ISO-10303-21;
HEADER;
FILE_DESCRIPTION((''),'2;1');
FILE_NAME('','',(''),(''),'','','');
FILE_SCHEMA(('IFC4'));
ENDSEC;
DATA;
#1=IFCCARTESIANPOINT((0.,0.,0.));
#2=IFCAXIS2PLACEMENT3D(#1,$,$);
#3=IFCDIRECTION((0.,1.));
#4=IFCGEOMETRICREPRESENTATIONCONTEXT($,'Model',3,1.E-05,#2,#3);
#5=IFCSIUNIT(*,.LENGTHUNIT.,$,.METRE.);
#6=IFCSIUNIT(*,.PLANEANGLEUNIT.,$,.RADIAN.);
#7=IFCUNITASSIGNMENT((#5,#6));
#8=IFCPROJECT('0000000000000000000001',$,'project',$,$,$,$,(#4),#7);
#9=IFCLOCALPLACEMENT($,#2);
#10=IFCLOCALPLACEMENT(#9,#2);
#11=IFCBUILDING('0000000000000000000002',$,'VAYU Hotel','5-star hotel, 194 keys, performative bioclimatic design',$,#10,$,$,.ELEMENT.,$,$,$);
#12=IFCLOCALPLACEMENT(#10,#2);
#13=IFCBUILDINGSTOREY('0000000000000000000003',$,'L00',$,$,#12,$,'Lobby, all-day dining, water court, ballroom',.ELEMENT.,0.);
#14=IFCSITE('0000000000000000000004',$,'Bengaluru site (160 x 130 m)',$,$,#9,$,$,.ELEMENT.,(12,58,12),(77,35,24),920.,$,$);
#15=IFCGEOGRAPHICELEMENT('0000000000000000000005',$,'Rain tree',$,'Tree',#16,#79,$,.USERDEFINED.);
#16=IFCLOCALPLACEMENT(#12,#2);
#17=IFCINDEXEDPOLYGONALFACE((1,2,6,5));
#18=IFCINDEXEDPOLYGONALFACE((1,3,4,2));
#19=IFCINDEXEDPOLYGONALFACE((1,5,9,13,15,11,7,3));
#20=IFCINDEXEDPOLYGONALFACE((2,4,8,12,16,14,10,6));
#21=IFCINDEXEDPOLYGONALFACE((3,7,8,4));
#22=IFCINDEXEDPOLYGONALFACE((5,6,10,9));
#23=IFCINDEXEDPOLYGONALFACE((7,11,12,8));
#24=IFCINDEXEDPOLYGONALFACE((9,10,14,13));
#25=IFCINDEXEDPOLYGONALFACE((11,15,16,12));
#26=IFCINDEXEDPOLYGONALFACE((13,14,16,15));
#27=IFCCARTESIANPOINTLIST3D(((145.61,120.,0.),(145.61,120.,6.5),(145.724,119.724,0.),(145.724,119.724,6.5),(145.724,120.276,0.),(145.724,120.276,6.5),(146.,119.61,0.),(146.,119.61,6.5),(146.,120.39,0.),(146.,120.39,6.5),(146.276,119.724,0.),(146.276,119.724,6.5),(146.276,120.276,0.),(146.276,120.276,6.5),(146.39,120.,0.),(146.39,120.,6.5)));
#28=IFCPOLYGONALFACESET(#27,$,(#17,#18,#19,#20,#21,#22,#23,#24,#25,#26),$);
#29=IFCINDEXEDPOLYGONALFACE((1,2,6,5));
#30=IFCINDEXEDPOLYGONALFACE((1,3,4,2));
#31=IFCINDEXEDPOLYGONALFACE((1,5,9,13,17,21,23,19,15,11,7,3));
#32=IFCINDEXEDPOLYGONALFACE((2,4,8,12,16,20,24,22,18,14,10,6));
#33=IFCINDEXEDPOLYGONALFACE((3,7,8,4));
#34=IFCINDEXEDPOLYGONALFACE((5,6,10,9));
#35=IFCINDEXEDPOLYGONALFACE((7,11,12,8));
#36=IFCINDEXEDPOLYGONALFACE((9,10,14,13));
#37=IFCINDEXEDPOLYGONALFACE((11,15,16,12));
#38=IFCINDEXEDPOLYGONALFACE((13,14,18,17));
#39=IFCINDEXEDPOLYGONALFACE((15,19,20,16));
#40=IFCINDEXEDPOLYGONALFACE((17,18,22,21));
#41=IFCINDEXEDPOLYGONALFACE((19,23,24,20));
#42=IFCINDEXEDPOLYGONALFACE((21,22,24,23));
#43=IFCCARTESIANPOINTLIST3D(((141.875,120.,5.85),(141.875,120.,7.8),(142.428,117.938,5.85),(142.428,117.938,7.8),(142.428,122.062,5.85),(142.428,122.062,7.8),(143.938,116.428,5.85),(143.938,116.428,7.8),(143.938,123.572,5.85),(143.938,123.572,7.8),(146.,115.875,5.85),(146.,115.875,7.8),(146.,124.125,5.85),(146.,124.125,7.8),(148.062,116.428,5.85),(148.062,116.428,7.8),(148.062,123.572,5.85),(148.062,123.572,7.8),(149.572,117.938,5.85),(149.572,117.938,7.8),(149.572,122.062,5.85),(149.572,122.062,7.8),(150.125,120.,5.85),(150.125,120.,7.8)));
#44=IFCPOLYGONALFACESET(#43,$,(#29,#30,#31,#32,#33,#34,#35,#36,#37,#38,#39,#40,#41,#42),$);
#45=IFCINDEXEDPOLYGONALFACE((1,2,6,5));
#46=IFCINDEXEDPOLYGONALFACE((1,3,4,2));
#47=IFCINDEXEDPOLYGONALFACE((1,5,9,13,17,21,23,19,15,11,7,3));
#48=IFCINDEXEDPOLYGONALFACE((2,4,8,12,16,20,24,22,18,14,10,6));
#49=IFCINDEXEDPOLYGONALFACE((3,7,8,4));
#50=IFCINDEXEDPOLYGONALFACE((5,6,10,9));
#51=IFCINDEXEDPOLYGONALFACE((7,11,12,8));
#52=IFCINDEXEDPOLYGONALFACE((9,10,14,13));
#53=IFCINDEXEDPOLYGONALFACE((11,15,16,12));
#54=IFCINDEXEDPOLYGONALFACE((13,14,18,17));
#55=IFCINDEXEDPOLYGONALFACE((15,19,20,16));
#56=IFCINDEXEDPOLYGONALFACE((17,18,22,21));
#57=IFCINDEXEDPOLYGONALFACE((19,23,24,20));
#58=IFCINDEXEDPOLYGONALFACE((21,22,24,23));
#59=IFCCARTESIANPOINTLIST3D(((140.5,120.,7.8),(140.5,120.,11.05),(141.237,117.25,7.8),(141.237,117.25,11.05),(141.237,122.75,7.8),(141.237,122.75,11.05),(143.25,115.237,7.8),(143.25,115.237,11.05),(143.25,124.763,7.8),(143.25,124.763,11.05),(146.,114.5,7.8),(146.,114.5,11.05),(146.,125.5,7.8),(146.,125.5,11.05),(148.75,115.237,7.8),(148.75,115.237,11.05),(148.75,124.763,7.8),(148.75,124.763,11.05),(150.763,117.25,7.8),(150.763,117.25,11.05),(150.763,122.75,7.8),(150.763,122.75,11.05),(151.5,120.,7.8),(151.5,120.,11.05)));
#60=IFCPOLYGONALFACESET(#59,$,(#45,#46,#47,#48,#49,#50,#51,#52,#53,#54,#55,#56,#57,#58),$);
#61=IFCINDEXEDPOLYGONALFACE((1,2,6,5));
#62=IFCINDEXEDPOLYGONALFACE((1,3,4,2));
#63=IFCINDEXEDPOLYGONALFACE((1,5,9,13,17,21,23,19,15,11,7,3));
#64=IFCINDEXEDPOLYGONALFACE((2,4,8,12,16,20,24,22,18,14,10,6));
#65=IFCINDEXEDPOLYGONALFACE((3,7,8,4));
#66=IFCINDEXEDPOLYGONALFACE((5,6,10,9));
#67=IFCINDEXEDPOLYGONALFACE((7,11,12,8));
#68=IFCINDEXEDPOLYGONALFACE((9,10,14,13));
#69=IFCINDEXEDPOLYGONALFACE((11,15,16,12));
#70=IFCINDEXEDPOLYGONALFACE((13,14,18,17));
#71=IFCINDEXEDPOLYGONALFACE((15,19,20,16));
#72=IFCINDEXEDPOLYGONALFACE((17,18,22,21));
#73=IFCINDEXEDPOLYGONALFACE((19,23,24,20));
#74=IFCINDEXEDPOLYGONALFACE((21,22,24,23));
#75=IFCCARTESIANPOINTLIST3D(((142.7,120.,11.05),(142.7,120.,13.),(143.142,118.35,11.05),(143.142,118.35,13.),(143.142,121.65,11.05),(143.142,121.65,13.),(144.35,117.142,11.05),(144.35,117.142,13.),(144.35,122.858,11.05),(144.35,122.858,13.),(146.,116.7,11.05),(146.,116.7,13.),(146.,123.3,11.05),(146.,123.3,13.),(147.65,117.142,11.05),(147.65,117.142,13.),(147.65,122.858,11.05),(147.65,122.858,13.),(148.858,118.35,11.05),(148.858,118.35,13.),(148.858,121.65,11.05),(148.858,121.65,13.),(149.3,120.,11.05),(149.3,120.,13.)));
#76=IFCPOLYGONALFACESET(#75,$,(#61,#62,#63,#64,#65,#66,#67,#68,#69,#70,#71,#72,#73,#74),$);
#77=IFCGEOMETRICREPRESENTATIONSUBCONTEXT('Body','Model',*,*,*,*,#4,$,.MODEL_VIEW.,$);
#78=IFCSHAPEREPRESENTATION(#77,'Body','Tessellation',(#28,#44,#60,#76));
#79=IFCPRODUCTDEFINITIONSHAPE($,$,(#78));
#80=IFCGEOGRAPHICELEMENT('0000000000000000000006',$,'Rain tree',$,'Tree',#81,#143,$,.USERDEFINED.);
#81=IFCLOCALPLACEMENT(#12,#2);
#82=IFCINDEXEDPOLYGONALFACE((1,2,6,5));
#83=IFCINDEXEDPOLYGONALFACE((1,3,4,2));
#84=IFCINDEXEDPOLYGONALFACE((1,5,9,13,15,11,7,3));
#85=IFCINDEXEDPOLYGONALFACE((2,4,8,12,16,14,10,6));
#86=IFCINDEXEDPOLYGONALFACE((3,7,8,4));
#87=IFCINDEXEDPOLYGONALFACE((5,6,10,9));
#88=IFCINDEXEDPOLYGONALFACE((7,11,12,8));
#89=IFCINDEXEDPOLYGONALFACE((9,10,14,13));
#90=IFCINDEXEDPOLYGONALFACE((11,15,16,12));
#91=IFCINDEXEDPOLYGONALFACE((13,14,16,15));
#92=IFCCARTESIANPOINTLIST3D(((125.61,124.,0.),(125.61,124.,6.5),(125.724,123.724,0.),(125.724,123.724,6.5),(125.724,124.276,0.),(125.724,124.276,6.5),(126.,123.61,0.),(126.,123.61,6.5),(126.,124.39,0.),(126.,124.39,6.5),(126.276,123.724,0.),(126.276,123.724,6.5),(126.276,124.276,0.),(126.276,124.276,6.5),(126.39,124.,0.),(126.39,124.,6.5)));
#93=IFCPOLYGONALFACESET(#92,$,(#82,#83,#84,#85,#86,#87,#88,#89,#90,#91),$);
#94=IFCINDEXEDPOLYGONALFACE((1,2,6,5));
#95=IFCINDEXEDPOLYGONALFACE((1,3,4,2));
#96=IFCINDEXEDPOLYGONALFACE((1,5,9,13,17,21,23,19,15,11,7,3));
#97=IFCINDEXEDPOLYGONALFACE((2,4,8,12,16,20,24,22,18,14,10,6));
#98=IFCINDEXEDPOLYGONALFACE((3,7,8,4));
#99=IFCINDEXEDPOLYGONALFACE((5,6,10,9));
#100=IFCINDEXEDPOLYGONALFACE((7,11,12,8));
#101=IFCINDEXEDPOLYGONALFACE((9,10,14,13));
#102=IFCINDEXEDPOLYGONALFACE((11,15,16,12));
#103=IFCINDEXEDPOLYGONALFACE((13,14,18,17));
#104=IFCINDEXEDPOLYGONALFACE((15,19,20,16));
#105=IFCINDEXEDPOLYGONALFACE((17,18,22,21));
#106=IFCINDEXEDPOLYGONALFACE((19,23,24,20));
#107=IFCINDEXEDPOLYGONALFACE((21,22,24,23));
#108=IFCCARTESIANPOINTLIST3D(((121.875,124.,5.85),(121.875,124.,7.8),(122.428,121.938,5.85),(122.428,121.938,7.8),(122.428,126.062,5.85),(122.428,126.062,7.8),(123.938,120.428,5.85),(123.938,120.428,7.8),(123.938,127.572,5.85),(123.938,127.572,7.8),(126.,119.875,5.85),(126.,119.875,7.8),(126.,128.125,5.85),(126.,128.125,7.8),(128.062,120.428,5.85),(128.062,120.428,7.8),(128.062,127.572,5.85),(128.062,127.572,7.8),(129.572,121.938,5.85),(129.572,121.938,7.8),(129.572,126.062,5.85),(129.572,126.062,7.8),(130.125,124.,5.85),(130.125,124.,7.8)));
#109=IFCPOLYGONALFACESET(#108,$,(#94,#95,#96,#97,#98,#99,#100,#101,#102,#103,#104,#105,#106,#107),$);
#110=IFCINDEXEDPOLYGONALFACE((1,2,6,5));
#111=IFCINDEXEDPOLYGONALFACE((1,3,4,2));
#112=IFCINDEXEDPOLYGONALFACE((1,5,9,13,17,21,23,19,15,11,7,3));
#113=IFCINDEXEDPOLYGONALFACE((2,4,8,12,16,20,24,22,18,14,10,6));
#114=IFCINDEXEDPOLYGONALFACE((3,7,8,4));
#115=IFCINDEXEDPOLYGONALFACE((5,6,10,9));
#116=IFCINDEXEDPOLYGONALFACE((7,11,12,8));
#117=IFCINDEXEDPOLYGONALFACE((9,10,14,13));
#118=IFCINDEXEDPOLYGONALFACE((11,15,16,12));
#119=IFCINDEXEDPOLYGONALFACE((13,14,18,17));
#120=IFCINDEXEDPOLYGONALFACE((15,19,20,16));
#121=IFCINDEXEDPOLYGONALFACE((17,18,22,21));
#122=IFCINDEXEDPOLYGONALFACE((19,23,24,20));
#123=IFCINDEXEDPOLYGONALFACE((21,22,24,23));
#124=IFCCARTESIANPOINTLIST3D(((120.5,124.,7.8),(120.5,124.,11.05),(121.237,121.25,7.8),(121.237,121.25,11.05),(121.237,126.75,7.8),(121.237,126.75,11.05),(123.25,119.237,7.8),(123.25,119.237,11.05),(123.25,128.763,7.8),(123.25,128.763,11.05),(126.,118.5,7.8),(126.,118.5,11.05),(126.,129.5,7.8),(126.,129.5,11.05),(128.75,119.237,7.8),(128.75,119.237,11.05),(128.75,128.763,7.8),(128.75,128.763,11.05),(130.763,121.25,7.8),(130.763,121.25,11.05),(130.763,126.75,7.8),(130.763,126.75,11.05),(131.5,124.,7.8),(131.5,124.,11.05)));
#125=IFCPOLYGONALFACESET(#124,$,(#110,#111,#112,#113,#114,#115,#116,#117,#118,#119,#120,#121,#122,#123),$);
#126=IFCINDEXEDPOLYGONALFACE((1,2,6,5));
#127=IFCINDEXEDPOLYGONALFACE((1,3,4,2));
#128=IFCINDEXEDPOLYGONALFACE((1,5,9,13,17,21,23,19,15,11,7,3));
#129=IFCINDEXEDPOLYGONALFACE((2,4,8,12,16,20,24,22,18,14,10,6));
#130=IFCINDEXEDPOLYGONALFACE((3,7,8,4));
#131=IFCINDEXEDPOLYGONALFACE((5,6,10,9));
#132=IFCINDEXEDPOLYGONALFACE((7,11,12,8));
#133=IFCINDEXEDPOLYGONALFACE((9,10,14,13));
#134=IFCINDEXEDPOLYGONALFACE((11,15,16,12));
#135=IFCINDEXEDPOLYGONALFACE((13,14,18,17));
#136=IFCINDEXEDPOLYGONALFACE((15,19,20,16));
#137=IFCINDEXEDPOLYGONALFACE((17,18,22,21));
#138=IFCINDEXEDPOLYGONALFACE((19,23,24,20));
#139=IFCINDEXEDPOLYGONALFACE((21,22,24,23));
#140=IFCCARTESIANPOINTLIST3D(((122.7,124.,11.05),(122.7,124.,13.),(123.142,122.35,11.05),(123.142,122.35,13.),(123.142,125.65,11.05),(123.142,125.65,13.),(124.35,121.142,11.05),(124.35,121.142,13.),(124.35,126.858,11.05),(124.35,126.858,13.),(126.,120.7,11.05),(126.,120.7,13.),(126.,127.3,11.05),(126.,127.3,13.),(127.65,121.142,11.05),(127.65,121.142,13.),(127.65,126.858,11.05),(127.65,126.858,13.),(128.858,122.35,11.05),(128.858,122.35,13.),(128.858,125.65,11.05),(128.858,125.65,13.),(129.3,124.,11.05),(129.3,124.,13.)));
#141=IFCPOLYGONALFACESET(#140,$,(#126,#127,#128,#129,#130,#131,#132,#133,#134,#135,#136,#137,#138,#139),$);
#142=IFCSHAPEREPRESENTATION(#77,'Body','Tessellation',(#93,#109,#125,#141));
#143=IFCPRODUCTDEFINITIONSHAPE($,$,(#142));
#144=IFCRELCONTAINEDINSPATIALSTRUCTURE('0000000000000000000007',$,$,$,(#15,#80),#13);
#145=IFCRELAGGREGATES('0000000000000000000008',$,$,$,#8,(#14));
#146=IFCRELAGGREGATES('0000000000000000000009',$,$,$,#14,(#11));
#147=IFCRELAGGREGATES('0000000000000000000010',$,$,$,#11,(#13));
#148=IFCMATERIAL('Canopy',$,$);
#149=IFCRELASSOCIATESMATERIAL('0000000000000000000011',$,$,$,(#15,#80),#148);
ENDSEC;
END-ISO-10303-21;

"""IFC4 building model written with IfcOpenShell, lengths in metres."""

from ifc_helpers import new_model, si_unit, direction, frame, origin, place, context, subcontext, project, spatial, polyline, outline, extrude, material, element, save


model = new_model("IFC4")

# Units and contexts
model_context = context("Model", 3, precision=1e-05, world=origin(), true_north=direction((0.0, 1.0)))
body_context = subcontext(model_context, "Body", "Model", "MODEL_VIEW")
ifc_project = project(units=[si_unit("LENGTHUNIT", "METRE"), si_unit("PLANEANGLEUNIT", "RADIAN")], contexts=[model_context])

# Site, building, storey
site_placement = place(None, origin())
site = spatial("IfcSite", under=ifc_project, at=site_placement, Name="Bengaluru site (160 x 130 m)", CompositionType="ELEMENT", RefLatitude=(12, 58, 12), RefLongitude=(77, 35, 24), RefElevation=920.0)
building_placement = place(site_placement, origin())
building = spatial("IfcBuilding", under=site, at=building_placement, Name="VAYU Hotel", Description="5-star hotel, 194 keys, performative bioclimatic design", CompositionType="ELEMENT")
storey_placement = place(building_placement, origin())
storey = spatial("IfcBuildingStorey", under=building, at=storey_placement, Name="L00", LongName="Lobby, all-day dining, water court, ballroom", CompositionType="ELEMENT", Elevation=0.0)

# Geographic elements
ifc_material_1 = material(Name="Canopy")
geographic_element_1_placement = place(storey_placement, origin())
element("IfcGeographicElement", 1, at=geographic_element_1_placement, inside=storey, material=ifc_material_1, Name="Rain tree", ObjectType="Tree", PredefinedType="USERDEFINED", context=body_context, shape_type="SweptSolid", body=[
    extrude(outline(polyline([(146.39, 120.0), (146.276, 120.276), (146.0, 120.39), (145.724, 120.276), (145.61, 120.0), (145.724, 119.724), (146.0, 119.61), (146.276, 119.724), (146.39, 120.0)])), origin(), (0.0, 0.0, 1.0), 6.5),
    extrude(outline(polyline([(150.125, 120.0), (149.572, 122.062), (148.062, 123.572), (146.0, 124.125), (143.938, 123.572), (142.428, 122.062), (141.875, 120.0), (142.428, 117.938), (143.938, 116.428), (146.0, 115.875), (148.062, 116.428), (149.572, 117.938), (150.125, 120.0)])), frame((0.0, 0.0, 5.85)), (0.0, 0.0, 1.0), 1.95),
    extrude(outline(polyline([(151.5, 120.0), (150.763, 122.75), (148.75, 124.763), (146.0, 125.5), (143.25, 124.763), (141.237, 122.75), (140.5, 120.0), (141.237, 117.25), (143.25, 115.237), (146.0, 114.5), (148.75, 115.237), (150.763, 117.25), (151.5, 120.0)])), frame((0.0, 0.0, 7.8)), (0.0, 0.0, 1.0), 3.25),
    extrude(outline(polyline([(149.3, 120.0), (148.858, 121.65), (147.65, 122.858), (146.0, 123.3), (144.35, 122.858), (143.142, 121.65), (142.7, 120.0), (143.142, 118.35), (144.35, 117.142), (146.0, 116.7), (147.65, 117.142), (148.858, 118.35), (149.3, 120.0)])), frame((0.0, 0.0, 11.05)), (0.0, 0.0, 1.0), 1.95),
])
geographic_element_2_placement = place(storey_placement, origin())
element("IfcGeographicElement", 2, at=geographic_element_2_placement, inside=storey, material=ifc_material_1, Name="Rain tree", ObjectType="Tree", PredefinedType="USERDEFINED", context=body_context, shape_type="SweptSolid", body=[
    extrude(outline(polyline([(126.39, 124.0), (126.276, 124.276), (126.0, 124.39), (125.724, 124.276), (125.61, 124.0), (125.724, 123.724), (126.0, 123.61), (126.276, 123.724), (126.39, 124.0)])), origin(), (0.0, 0.0, 1.0), 6.5),
    extrude(outline(polyline([(130.125, 124.0), (129.572, 126.062), (128.062, 127.572), (126.0, 128.125), (123.938, 127.572), (122.428, 126.062), (121.875, 124.0), (122.428, 121.938), (123.938, 120.428), (126.0, 119.875), (128.062, 120.428), (129.572, 121.938), (130.125, 124.0)])), frame((0.0, 0.0, 5.85)), (0.0, 0.0, 1.0), 1.95),
    extrude(outline(polyline([(131.5, 124.0), (130.763, 126.75), (128.75, 128.763), (126.0, 129.5), (123.25, 128.763), (121.237, 126.75), (120.5, 124.0), (121.237, 121.25), (123.25, 119.237), (126.0, 118.5), (128.75, 119.237), (130.763, 121.25), (131.5, 124.0)])), frame((0.0, 0.0, 7.8)), (0.0, 0.0, 1.0), 3.25),
    extrude(outline(polyline([(129.3, 124.0), (128.858, 125.65), (127.65, 126.858), (126.0, 127.3), (124.35, 126.858), (123.142, 125.65), (122.7, 124.0), (123.142, 122.35), (124.35, 121.142), (126.0, 120.7), (127.65, 121.142), (128.858, 122.35), (129.3, 124.0)])), frame((0.0, 0.0, 11.05)), (0.0, 0.0, 1.0), 1.95),
])

save(model, "model.ifc")
